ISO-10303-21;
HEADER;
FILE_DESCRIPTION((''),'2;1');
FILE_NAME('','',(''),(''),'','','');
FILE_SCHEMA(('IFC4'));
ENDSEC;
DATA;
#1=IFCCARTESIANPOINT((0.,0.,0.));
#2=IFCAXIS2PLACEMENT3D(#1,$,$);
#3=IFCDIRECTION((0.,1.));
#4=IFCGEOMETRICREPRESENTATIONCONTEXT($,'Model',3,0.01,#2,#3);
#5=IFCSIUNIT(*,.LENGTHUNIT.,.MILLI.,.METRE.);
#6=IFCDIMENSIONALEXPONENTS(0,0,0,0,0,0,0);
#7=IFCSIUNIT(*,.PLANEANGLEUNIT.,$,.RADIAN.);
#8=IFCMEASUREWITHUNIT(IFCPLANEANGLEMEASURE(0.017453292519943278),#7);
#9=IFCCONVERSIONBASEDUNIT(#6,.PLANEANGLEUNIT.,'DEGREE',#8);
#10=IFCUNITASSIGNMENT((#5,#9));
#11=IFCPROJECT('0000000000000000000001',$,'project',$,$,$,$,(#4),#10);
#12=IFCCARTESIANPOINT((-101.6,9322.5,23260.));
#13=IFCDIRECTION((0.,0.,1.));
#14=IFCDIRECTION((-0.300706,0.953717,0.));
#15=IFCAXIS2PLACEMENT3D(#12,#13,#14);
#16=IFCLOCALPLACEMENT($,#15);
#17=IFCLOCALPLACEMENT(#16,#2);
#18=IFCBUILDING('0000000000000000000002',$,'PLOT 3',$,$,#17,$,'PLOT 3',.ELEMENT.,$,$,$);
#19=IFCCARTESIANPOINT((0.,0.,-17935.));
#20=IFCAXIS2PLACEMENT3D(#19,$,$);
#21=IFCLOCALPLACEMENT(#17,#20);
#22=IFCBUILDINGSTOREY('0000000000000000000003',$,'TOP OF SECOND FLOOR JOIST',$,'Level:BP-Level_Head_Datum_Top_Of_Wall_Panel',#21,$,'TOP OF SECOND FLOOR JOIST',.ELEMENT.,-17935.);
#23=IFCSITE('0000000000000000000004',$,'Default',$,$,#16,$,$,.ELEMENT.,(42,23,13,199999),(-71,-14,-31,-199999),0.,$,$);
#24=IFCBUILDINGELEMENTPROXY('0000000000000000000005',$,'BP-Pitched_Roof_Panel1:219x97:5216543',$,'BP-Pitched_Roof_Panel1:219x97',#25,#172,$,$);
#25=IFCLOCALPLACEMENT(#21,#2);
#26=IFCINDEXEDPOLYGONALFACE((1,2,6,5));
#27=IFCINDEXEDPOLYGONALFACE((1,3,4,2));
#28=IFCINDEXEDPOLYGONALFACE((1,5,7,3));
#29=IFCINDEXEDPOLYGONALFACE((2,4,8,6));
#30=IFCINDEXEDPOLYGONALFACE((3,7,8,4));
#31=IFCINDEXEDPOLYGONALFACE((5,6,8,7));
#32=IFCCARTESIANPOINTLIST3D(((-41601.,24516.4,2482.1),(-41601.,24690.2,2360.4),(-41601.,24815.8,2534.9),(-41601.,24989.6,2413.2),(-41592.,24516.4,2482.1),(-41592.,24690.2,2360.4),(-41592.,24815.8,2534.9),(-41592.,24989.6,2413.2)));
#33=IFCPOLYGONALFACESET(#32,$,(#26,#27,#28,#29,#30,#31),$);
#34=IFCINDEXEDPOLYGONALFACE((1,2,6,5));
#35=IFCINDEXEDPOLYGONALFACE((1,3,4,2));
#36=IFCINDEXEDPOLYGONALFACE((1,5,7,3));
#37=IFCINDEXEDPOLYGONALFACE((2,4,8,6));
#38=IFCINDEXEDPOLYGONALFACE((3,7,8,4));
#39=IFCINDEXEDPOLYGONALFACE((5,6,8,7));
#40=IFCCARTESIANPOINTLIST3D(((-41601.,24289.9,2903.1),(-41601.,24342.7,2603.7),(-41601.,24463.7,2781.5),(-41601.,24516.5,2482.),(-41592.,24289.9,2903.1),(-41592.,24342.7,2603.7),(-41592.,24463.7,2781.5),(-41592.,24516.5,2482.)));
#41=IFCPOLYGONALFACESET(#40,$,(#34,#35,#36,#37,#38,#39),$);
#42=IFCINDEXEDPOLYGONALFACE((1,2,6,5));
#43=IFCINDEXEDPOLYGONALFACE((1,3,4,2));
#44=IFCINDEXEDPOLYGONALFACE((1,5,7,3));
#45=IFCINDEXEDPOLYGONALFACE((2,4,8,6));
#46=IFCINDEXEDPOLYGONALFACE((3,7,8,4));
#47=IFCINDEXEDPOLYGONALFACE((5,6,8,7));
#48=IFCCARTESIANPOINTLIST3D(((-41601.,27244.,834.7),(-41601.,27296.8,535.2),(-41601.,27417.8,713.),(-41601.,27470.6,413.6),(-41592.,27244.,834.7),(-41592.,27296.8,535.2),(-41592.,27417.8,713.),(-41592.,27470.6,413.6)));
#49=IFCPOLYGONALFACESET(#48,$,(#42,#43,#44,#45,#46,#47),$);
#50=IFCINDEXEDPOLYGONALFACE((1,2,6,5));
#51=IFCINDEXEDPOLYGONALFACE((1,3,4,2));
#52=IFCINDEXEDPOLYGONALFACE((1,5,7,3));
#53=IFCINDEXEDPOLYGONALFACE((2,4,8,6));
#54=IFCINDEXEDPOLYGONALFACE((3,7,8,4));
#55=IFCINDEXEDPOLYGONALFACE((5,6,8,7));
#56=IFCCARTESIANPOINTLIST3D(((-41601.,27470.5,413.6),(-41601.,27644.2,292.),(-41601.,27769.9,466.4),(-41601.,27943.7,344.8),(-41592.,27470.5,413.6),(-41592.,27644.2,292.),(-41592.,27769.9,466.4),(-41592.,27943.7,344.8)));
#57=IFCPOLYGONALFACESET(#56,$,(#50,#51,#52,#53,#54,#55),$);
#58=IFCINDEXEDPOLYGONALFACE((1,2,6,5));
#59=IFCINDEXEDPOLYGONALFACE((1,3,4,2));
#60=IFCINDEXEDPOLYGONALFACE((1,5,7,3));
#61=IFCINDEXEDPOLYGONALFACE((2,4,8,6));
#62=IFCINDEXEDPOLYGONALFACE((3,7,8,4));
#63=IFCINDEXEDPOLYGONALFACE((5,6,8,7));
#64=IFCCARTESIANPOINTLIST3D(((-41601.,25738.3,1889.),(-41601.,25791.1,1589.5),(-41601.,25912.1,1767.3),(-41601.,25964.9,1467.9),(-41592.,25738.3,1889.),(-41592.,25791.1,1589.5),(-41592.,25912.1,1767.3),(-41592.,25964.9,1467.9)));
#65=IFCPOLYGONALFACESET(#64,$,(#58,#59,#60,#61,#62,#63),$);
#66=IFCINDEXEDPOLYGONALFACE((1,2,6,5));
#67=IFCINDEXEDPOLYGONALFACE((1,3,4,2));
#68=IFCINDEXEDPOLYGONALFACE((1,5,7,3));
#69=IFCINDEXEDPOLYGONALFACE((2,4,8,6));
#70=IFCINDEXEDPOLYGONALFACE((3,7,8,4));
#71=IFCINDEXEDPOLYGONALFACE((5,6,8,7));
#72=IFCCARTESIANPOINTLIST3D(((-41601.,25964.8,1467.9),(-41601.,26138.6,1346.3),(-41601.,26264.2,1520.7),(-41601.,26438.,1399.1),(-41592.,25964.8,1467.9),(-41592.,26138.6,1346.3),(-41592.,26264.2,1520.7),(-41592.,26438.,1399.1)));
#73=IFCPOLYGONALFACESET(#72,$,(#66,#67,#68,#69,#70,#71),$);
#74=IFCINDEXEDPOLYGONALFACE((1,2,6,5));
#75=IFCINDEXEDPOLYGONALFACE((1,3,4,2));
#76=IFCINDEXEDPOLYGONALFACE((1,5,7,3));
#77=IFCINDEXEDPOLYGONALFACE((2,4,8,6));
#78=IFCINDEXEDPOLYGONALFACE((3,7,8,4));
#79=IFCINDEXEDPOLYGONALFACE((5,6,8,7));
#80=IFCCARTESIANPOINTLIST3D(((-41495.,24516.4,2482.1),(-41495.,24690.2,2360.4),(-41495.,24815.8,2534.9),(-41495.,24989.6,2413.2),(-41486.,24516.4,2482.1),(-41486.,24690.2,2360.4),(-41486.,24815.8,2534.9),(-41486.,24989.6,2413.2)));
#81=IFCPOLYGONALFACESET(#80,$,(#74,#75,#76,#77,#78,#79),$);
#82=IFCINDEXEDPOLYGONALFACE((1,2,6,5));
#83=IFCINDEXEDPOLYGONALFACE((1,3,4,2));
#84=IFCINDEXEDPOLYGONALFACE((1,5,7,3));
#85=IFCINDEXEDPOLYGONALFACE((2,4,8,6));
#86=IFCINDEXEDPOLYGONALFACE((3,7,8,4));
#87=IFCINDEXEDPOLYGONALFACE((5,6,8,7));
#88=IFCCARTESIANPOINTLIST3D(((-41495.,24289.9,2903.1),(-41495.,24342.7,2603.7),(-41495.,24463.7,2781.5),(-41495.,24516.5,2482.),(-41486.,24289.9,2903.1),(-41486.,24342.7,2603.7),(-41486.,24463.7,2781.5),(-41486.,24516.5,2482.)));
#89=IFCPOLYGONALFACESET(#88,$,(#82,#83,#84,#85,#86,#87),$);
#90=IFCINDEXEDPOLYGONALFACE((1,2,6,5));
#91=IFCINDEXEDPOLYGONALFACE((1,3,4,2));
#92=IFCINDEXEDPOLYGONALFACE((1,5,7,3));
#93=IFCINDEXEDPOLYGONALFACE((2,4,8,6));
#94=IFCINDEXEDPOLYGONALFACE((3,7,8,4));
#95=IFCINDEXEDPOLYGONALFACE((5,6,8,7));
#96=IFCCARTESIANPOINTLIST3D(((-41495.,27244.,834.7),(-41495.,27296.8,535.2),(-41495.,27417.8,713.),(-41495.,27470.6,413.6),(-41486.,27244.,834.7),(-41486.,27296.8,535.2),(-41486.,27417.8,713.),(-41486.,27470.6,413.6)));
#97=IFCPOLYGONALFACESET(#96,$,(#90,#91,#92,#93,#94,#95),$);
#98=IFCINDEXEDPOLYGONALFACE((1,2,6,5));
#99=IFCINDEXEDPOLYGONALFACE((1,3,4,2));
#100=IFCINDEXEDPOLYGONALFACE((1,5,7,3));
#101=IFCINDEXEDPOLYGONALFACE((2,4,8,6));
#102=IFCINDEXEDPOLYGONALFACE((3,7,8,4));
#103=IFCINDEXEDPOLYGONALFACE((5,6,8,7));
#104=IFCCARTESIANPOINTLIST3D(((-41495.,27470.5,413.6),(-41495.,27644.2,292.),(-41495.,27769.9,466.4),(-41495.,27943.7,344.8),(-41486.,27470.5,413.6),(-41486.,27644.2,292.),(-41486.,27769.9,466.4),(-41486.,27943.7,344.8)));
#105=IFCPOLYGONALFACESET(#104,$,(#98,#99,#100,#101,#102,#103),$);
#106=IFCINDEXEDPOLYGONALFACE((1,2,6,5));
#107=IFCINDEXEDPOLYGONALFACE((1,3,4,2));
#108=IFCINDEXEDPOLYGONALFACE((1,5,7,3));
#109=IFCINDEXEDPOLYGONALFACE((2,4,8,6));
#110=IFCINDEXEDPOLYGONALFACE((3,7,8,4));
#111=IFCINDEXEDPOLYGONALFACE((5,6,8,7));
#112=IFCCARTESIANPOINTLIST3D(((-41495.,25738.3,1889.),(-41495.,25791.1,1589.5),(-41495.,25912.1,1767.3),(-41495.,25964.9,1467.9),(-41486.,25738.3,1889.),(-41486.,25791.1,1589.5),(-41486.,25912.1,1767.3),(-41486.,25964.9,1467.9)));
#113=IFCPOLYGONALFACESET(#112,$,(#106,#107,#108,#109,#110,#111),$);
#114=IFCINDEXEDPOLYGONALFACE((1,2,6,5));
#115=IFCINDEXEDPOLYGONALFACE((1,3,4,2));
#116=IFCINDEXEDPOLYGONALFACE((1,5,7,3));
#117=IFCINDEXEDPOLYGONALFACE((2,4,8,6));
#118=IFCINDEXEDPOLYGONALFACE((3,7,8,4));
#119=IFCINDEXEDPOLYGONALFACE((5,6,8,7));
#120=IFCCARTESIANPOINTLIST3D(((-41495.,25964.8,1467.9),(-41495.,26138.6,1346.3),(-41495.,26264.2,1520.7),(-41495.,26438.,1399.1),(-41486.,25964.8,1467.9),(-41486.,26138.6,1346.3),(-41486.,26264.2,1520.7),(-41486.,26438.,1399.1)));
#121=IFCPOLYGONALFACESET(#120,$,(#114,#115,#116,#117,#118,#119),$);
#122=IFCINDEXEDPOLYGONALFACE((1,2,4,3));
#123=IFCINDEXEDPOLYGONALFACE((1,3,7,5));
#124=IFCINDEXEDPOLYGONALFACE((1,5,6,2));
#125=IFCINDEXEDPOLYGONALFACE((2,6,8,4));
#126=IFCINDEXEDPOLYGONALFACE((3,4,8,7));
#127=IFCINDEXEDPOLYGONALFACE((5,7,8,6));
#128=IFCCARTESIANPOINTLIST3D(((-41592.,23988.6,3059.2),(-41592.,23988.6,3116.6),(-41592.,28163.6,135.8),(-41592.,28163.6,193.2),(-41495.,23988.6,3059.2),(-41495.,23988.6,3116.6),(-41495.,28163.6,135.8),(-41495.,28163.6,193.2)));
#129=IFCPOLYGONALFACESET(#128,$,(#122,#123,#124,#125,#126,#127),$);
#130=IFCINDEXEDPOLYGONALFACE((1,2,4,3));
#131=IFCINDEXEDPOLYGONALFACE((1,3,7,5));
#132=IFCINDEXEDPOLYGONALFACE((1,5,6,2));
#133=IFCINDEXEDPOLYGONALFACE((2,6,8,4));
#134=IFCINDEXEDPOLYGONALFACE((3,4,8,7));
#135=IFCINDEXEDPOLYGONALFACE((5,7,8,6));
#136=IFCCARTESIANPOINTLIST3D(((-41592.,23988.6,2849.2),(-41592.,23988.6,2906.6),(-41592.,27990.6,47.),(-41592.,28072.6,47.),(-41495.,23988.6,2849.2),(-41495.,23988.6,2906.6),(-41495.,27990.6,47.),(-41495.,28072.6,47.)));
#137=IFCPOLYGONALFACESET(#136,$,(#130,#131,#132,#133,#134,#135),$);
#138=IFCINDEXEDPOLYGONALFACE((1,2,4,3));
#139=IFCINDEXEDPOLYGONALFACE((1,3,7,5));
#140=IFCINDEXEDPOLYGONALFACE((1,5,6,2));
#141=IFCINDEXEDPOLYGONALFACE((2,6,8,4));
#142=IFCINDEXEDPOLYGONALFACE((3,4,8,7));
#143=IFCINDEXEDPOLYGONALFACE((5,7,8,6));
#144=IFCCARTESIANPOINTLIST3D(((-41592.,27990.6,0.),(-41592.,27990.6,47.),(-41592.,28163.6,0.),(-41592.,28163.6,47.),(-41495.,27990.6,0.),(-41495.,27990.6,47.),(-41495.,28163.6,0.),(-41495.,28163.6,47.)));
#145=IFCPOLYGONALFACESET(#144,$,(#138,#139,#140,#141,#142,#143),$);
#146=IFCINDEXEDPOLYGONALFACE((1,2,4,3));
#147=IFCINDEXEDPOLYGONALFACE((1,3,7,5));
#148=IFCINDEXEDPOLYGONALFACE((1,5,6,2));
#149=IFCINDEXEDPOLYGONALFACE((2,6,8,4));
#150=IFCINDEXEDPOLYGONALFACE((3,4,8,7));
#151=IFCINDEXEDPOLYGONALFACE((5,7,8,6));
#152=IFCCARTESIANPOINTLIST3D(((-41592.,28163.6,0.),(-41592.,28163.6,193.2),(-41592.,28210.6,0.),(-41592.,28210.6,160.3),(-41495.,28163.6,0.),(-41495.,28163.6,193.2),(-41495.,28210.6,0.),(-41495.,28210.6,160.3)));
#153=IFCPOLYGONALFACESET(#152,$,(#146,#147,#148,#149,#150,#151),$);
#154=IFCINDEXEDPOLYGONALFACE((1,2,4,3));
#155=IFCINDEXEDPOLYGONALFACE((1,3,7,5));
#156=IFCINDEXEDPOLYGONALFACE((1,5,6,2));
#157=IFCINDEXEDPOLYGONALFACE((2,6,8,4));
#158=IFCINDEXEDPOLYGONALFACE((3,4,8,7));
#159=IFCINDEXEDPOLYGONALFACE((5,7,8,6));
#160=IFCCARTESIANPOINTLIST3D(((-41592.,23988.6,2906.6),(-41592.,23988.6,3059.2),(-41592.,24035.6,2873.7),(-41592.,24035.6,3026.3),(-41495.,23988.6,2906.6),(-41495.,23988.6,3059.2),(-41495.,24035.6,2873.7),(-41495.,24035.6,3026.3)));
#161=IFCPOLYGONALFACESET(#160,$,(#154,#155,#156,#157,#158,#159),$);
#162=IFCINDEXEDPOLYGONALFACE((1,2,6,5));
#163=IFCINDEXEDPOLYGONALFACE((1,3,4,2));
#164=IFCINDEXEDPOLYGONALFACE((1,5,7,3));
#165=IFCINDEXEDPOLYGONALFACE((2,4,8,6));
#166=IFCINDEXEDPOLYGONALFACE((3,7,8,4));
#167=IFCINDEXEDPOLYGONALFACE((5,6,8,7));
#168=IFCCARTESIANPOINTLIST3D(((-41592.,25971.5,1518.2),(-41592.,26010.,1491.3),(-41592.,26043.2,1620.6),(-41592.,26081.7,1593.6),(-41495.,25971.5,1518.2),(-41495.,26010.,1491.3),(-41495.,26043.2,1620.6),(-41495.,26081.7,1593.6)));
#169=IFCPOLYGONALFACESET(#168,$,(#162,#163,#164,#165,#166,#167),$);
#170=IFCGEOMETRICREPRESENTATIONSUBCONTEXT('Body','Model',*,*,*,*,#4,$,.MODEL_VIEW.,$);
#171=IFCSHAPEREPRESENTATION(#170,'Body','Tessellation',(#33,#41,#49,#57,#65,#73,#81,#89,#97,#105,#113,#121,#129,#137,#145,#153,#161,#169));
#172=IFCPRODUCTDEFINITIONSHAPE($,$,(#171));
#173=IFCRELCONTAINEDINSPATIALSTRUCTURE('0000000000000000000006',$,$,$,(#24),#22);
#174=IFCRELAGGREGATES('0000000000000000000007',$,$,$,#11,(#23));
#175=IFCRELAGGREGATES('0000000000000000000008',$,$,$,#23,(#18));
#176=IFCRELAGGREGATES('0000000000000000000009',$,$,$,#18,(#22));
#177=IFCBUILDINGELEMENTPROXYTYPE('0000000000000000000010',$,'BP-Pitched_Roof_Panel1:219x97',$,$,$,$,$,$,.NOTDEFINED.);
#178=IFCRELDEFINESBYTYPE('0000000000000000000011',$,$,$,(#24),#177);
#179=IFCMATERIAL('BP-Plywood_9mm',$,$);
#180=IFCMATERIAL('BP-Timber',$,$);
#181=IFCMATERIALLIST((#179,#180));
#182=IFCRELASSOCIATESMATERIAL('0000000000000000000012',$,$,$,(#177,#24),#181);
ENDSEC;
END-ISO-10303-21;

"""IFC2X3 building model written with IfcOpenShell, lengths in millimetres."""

from ifc_helpers import new_model, entity, si_unit, converted_unit, direction, frame, frame_2d, origin, origin_2d_with_axis, place, context, subcontext, project, spatial, polyline, rectangle, outline, extrude, source, transform, mapped, material, material_list, type_object, type_shapes, element, save


model = new_model("IFC2X3")

# Units and contexts
model_context = context("Model", 3, precision=0.01, world=origin(), true_north=direction((0.0, 1.0)))
body_context = subcontext(model_context, "Body", "Model", "MODEL_VIEW")
ifc_project = project(units=[si_unit("LENGTHUNIT", "METRE", prefix="MILLI"), converted_unit("PLANEANGLEUNIT", "DEGREE", entity("IfcPlaneAngleMeasure", 0.017453292519943278), si_unit("PLANEANGLEUNIT", "RADIAN"), dimensions=[0, 0, 0, 0, 0, 0, 0])], contexts=[model_context])

# Site, building, storey
site_placement = place(None, frame((-101.6, 9322.5, 23260.0), z_axis=(0.0, 0.0, 1.0), x_axis=(-0.300706, 0.953717, 0.0)))
site = spatial("IfcSite", under=ifc_project, at=site_placement, Name="Default", CompositionType="ELEMENT", RefLatitude=(42, 23, 13, 199999), RefLongitude=(-71, -14, -31, -199999), RefElevation=0.0)
building_placement = place(site_placement, origin())
building = spatial("IfcBuilding", under=site, at=building_placement, Name="PLOT 3", LongName="PLOT 3", CompositionType="ELEMENT")
storey_placement = place(building_placement, frame((0.0, 0.0, -17935.0)))
storey = spatial("IfcBuildingStorey", under=building, at=storey_placement, Name="TOP OF SECOND FLOOR JOIST", ObjectType="Level:BP-Level_Head_Datum_Top_Of_Wall_Panel", LongName="TOP OF SECOND FLOOR JOIST", CompositionType="ELEMENT", Elevation=-17935.0)

# Building element proxy
ifc_material_1 = material(Name="BP-Timber")
ifc_material_2 = material(Name="BP-Plywood_9mm")
ifc_material_list = material_list([ifc_material_2, ifc_material_1])
building_element_proxy_type_1 = type_object("IfcBuildingElementProxyType", Name="BP-Pitched_Roof_Panel1:219x97", PredefinedType="NOTDEFINED", material=ifc_material_list)
shared_shape_1 = source(origin(), body_context, "Body", "SweptSolid", [
    extrude(outline(polyline([(-77.0, -75.0), (227.0, -75.0), (77.0, 75.0), (-227.0, 75.0), (-77.0, -75.0)])), frame((35.3, -3956.0, 2447.7), z_axis=(0.0, 1.0, 0.0), x_axis=(-0.984808, 0.0, 0.173648)), (0.0, 0.0, 1.0), 9.0),
    extrude(outline(polyline([(1.4, -107.5), (213.6, -107.5), (-1.4, 107.5), (-213.6, 107.5), (1.4, -107.5)])), frame((385.1, -3956.0, 2692.6), z_axis=(0.0, 1.0, 0.0), x_axis=(-0.819152, 0.0, -0.573576)), (0.0, 0.0, 1.0), 9.0),
    extrude(outline(polyline([(1.4, -107.5), (213.6, -107.5), (-1.4, 107.5), (-213.6, 107.5), (1.4, -107.5)])), frame((-2569.0, -3956.0, 624.1), z_axis=(0.0, 1.0, 0.0), x_axis=(-0.819152, 0.0, -0.573576)), (0.0, 0.0, 1.0), 9.0),
    extrude(outline(polyline([(-77.0, -75.0), (227.0, -75.0), (77.0, 75.0), (-227.0, 75.0), (-77.0, -75.0)])), frame((-2918.8, -3956.0, 379.2), z_axis=(0.0, 1.0, 0.0), x_axis=(-0.984808, 0.0, 0.173648)), (0.0, 0.0, 1.0), 9.0),
    extrude(outline(polyline([(1.4, -107.5), (213.6, -107.5), (-1.4, 107.5), (-213.6, 107.5), (1.4, -107.5)])), frame((-1063.3, -3956.0, 1678.4), z_axis=(0.0, 1.0, 0.0), x_axis=(-0.819152, 0.0, -0.573576)), (0.0, 0.0, 1.0), 9.0),
    extrude(outline(polyline([(-77.0, -75.0), (227.0, -75.0), (77.0, 75.0), (-227.0, 75.0), (-77.0, -75.0)])), frame((-1413.1, -3956.0, 1433.5), z_axis=(0.0, 1.0, 0.0), x_axis=(-0.984808, 0.0, 0.173648)), (0.0, 0.0, 1.0), 9.0),
    extrude(outline(polyline([(-77.0, -75.0), (227.0, -75.0), (77.0, 75.0), (-227.0, 75.0), (-77.0, -75.0)])), frame((35.3, -3850.0, 2447.7), z_axis=(0.0, 1.0, 0.0), x_axis=(-0.984808, 0.0, 0.173648)), (0.0, 0.0, 1.0), 9.0),
    extrude(outline(polyline([(1.4, -107.5), (213.6, -107.5), (-1.4, 107.5), (-213.6, 107.5), (1.4, -107.5)])), frame((385.1, -3850.0, 2692.6), z_axis=(0.0, 1.0, 0.0), x_axis=(-0.819152, 0.0, -0.573576)), (0.0, 0.0, 1.0), 9.0),
    extrude(outline(polyline([(1.4, -107.5), (213.6, -107.5), (-1.4, 107.5), (-213.6, 107.5), (1.4, -107.5)])), frame((-2569.0, -3850.0, 624.1), z_axis=(0.0, 1.0, 0.0), x_axis=(-0.819152, 0.0, -0.573576)), (0.0, 0.0, 1.0), 9.0),
    extrude(outline(polyline([(-77.0, -75.0), (227.0, -75.0), (77.0, 75.0), (-227.0, 75.0), (-77.0, -75.0)])), frame((-2918.8, -3850.0, 379.2), z_axis=(0.0, 1.0, 0.0), x_axis=(-0.984808, 0.0, 0.173648)), (0.0, 0.0, 1.0), 9.0),
    extrude(outline(polyline([(1.4, -107.5), (213.6, -107.5), (-1.4, 107.5), (-213.6, 107.5), (1.4, -107.5)])), frame((-1063.3, -3850.0, 1678.4), z_axis=(0.0, 1.0, 0.0), x_axis=(-0.819152, 0.0, -0.573576)), (0.0, 0.0, 1.0), 9.0),
    extrude(outline(polyline([(-77.0, -75.0), (227.0, -75.0), (77.0, 75.0), (-227.0, 75.0), (-77.0, -75.0)])), frame((-1413.1, -3850.0, 1433.5), z_axis=(0.0, 1.0, 0.0), x_axis=(-0.984808, 0.0, 0.173648)), (0.0, 0.0, 1.0), 9.0),
    extrude(outline(polyline([(-1490.4, -2087.5), (-1433.0, -2087.5), (1490.4, 2087.5), (1433.0, 2087.5), (-1490.4, -2087.5)])), frame((-1287.8, -3947.0, 1626.2), z_axis=(0.0, 1.0, 0.0), x_axis=(0.0, 0.0, -1.0)), (0.0, 0.0, 1.0), 97.0),
    extrude(outline(polyline([(-1444.1, -2021.5), (-1386.8, -2021.5), (1415.5, 1980.5), (1415.5, 2062.5), (-1444.1, -2021.5)])), frame((-1221.8, -3947.0, 1462.5), z_axis=(0.0, 1.0, 0.0), x_axis=(0.0, 0.0, -1.0)), (0.0, 0.0, 1.0), 97.0),
    extrude(rectangle(XDim=173.0, YDim=97.0, at=origin_2d_with_axis()), frame((-3288.8, -3898.5, 0.0), z_axis=(0.0, 0.0, 1.0), x_axis=(-1.0, 0.0, 0.0)), (0.0, 0.0, 1.0), 47.0),
    extrude(outline(polyline([(22.0, -72.4), (79.4, -72.4), (-31.4, 85.9), (-69.9, 58.9), (22.0, -72.4)])), frame((-3398.8, -3947.0, 88.4), z_axis=(0.0, 1.0, 0.0), x_axis=(0.819152, 0.0, 0.573576)), (0.0, 0.0, 1.0), 97.0),
    extrude(outline(polyline([(15.1, -62.5), (72.5, -62.5), (-15.1, 62.5), (-72.5, 62.5), (15.1, -62.5)])), frame((776.2, -3947.0, 2966.5), z_axis=(0.0, 1.0, 0.0), x_axis=(0.819152, 0.0, 0.573576)), (0.0, 0.0, 1.0), 97.0),
    extrude(rectangle(XDim=47.0, YDim=97.0, at=frame_2d((0.0, 0.0), x_axis=(1.0, 0.0))), frame((-1202.4, -3898.5, 1504.7), z_axis=(-0.573576, 0.0, 0.819152), x_axis=(-0.819152, 0.0, -0.573576)), (0.0, 0.0, 1.0), 125.0),
])
type_shapes(building_element_proxy_type_1, [shared_shape_1])
for number, where, z_axis, x_axis, name in (
    (1, (-37645.0, 24788.3, 0.0), (0.0, 0.0, 1.0), (0.0, -1.0, 0.0), "BP-Pitched_Roof_Panel1:219x97:5216543"),
):
    element("IfcBuildingElementProxy", number, at=place(storey_placement, frame(where, z_axis=z_axis, x_axis=x_axis)), inside=storey, type_object=building_element_proxy_type_1, material=ifc_material_list, Name=name, ObjectType="BP-Pitched_Roof_Panel1:219x97", context=body_context, shape_type="MappedRepresentation", body=[
        mapped(shared_shape_1, transform((0.0, 0.0, 0.0), scale=1.0)),
    ])

save(model, "model.ifc")
